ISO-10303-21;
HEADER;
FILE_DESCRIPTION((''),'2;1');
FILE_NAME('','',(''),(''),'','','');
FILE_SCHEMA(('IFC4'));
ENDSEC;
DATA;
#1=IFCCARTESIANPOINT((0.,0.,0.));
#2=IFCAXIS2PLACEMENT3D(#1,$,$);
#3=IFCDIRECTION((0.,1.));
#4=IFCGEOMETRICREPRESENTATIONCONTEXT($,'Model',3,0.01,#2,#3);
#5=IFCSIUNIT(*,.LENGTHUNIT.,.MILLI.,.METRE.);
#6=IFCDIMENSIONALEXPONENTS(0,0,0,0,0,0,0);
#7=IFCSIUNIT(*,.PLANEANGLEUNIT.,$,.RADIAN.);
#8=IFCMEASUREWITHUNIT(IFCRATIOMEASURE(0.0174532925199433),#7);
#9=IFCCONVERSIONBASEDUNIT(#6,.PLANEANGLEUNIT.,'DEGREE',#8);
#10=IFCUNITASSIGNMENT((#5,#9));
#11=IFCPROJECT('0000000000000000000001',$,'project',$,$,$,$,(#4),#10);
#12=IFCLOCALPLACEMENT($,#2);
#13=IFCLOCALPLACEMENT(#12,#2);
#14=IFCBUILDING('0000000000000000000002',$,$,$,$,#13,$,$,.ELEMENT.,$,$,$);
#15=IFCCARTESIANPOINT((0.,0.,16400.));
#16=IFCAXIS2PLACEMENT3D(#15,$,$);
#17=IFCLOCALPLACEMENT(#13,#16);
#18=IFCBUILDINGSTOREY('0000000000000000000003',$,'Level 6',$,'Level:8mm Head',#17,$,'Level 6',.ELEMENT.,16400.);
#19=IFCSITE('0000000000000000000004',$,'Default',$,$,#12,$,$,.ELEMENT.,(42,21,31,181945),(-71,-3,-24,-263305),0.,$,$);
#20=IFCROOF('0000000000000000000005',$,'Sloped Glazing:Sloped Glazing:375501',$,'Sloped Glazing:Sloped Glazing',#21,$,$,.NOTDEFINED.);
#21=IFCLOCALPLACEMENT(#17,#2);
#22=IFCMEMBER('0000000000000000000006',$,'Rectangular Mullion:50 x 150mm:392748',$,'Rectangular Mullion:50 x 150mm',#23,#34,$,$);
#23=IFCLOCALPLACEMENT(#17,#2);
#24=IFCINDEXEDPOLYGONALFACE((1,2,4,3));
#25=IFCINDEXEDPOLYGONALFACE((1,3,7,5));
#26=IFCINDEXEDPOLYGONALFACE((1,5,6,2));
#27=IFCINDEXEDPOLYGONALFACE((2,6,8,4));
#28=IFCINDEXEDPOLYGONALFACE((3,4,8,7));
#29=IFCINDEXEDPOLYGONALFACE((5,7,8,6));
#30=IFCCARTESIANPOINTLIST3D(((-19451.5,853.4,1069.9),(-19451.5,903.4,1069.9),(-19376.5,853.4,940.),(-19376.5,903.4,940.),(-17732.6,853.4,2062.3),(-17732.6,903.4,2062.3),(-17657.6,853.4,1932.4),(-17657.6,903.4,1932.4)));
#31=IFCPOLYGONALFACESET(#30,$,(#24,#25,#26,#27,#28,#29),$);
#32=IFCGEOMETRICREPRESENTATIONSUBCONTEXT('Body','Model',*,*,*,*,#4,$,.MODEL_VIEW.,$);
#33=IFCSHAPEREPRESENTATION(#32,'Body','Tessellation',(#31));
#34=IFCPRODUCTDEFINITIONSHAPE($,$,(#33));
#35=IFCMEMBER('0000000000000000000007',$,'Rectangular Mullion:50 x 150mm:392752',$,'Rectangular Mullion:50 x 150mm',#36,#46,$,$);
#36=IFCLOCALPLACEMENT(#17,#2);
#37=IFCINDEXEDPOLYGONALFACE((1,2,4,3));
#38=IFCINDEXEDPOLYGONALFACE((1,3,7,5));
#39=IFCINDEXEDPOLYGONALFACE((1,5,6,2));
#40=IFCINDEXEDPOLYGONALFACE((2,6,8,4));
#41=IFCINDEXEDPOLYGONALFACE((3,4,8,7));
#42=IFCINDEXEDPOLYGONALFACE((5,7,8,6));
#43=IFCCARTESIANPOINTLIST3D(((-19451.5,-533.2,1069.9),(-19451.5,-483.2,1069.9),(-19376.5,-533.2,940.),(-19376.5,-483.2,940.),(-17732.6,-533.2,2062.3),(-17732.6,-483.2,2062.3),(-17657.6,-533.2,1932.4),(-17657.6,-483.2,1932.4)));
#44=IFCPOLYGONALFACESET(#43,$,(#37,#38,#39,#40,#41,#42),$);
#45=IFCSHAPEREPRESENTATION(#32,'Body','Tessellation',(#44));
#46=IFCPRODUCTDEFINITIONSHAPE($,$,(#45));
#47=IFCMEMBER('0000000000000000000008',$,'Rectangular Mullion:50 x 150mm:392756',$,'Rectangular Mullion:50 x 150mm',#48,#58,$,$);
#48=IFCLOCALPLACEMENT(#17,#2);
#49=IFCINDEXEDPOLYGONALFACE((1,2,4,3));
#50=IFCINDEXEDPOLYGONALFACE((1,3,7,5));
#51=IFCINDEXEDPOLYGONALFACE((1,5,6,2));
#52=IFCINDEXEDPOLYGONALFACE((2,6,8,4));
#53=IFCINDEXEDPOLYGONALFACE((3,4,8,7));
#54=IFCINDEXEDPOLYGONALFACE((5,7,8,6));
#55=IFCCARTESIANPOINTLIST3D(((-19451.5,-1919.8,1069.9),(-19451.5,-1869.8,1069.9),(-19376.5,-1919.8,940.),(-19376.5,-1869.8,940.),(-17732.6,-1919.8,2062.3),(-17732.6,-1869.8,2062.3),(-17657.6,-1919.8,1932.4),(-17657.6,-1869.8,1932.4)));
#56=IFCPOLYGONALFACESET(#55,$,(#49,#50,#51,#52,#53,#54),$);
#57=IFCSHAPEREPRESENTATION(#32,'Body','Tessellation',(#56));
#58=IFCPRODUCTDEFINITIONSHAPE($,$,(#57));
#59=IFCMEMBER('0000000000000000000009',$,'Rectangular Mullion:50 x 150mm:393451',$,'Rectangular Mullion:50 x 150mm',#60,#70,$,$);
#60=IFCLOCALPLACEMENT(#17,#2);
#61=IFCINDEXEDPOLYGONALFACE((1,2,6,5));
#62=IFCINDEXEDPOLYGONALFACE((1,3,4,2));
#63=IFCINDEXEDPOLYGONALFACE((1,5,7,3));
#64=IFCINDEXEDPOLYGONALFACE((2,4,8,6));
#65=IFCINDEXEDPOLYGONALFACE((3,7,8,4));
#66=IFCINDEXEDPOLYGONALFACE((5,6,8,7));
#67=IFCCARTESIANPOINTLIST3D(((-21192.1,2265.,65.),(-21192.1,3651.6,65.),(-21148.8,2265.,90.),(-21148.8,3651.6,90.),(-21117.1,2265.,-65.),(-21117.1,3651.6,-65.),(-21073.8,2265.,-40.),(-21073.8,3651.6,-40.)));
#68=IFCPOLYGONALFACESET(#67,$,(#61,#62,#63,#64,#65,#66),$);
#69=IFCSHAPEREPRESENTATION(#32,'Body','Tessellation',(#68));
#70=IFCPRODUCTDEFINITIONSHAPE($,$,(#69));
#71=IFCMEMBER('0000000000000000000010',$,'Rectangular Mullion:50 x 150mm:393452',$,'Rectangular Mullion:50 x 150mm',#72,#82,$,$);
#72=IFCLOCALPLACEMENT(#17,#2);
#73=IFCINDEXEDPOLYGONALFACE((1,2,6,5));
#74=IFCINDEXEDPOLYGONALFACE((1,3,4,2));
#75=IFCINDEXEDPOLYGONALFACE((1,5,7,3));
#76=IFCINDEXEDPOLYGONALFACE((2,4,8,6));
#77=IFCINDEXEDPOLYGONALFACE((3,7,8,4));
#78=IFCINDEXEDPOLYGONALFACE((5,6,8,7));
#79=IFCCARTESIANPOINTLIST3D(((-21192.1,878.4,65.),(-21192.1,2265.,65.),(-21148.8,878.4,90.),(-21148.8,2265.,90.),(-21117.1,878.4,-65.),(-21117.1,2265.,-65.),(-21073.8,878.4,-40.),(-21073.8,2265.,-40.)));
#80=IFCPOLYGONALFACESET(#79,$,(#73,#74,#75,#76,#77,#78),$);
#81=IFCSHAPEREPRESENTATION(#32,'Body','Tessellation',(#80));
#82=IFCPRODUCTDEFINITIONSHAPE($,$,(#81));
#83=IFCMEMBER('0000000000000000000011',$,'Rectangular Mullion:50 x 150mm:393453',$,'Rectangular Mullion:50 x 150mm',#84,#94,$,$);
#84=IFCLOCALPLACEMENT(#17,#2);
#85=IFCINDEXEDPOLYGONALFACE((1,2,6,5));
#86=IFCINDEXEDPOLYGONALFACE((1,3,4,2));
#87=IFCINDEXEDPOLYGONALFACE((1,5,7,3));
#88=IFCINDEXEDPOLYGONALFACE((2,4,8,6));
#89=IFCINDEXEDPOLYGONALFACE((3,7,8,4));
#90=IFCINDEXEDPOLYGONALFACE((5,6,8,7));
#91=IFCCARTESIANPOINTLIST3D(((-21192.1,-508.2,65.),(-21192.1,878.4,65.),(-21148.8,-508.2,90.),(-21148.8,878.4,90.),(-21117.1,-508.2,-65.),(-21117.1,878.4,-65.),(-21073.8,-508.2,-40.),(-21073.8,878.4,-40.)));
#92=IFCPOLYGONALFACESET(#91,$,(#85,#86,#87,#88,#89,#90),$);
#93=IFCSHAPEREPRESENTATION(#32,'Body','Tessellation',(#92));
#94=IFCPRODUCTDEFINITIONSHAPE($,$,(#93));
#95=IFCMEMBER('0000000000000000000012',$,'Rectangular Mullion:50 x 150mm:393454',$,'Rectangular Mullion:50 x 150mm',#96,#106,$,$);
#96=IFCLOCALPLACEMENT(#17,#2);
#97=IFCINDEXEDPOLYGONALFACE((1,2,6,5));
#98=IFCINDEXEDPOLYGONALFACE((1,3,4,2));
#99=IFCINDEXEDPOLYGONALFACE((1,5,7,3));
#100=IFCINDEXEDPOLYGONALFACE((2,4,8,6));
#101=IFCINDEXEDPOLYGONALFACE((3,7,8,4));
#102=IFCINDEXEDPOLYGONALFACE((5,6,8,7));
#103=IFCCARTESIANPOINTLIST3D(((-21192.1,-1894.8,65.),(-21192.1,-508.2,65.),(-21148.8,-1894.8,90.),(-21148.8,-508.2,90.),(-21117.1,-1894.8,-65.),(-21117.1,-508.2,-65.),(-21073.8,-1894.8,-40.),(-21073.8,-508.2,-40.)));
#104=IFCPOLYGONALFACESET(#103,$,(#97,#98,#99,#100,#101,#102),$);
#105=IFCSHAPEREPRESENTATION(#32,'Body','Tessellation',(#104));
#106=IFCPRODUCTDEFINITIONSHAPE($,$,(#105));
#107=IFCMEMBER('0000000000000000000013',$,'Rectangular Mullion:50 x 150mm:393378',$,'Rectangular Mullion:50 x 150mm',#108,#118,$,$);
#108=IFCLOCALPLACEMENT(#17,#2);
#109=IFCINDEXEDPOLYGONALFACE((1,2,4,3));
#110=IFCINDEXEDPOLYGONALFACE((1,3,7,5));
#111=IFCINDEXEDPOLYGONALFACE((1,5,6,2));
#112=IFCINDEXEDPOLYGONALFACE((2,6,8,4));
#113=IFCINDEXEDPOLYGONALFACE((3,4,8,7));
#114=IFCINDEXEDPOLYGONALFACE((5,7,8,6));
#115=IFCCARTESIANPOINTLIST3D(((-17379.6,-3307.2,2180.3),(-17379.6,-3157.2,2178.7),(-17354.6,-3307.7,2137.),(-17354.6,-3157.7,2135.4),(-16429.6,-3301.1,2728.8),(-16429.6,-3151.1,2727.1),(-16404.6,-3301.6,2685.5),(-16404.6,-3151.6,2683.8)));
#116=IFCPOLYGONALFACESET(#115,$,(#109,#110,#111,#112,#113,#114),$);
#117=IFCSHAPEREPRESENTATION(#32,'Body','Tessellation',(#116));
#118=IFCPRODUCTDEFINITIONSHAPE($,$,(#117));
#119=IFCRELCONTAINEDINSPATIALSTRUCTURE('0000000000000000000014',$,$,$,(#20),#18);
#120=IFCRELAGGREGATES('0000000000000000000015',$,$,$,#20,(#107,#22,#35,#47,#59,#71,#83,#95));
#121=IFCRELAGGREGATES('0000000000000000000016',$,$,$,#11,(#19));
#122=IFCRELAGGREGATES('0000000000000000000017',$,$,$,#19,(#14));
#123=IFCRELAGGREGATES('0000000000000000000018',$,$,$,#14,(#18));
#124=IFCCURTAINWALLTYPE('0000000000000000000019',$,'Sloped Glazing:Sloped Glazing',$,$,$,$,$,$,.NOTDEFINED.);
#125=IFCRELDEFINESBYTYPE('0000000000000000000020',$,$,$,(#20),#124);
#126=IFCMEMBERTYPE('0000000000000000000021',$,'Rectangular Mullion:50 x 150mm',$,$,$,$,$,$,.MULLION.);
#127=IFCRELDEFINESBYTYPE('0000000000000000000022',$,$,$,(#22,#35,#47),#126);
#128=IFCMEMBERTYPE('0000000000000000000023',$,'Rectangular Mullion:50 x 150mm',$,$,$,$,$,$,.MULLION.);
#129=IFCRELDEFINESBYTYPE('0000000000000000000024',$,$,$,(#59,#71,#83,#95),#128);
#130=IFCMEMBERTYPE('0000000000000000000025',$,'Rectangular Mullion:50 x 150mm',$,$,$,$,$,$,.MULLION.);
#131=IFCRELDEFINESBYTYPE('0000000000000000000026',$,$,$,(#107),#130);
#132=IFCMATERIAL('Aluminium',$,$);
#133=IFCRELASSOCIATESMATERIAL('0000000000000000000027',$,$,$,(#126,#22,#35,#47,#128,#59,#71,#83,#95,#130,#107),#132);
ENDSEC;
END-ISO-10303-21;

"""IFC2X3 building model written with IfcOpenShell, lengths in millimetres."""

from ifc_helpers import new_model, entity, si_unit, converted_unit, direction, frame, origin, origin_2d_with_axis, place, context, subcontext, project, spatial, rectangle, extrude, source, transform, mapped, material, type_object, type_shapes, element, aggregate, save


model = new_model("IFC2X3")

# Units and contexts
model_context = context("Model", 3, precision=0.01, world=origin(), true_north=direction((0.0, 1.0)))
body_context = subcontext(model_context, "Body", "Model", "MODEL_VIEW")
ifc_project = project(units=[si_unit("LENGTHUNIT", "METRE", prefix="MILLI"), converted_unit("PLANEANGLEUNIT", "DEGREE", entity("IfcRatioMeasure", 0.0174532925199433), si_unit("PLANEANGLEUNIT", "RADIAN"), dimensions=[0, 0, 0, 0, 0, 0, 0])], contexts=[model_context])

# Site, building, storey
site_placement = place(None, frame((0.0, 0.0, 0.0)))
site = spatial("IfcSite", under=ifc_project, at=site_placement, Name="Default", CompositionType="ELEMENT", RefLatitude=(42, 21, 31, 181945), RefLongitude=(-71, -3, -24, -263305), RefElevation=0.0)
building_placement = place(site_placement, origin())
building = spatial("IfcBuilding", under=site, at=building_placement, CompositionType="ELEMENT")
storey_placement = place(building_placement, frame((0.0, 0.0, 16400.0)))
storey = spatial("IfcBuildingStorey", under=building, at=storey_placement, Name="Level 6", ObjectType="Level:8mm Head", LongName="Level 6", CompositionType="ELEMENT", Elevation=16400.0)

# Roof, members
curtain_wall_type = type_object("IfcCurtainWallType", Name="Sloped Glazing:Sloped Glazing", PredefinedType="NOTDEFINED")
roof_placement = place(storey_placement, frame((0.0, 0.0, -16400.0)))
roof = element("IfcRoof", 1, at=roof_placement, inside=storey, type_object=curtain_wall_type, Name="Sloped Glazing:Sloped Glazing:375501", ObjectType="Sloped Glazing:Sloped Glazing", ShapeType="NOTDEFINED")
ifc_material_1 = material(Name="Aluminium")
member_type_1 = type_object("IfcMemberType", Name="Rectangular Mullion:50 x 150mm", PredefinedType="MULLION", material=ifc_material_1)
shared_shape_1 = source(origin(), body_context, "Body", "SweptSolid", [
    extrude(rectangle(XDim=150.0, YDim=50.0, at=origin_2d_with_axis()), frame((0.0, 0.0, -1984.8), z_axis=(0.0, 0.0, 1.0), x_axis=(0.0, -1.0, 0.0)), (0.0, 0.0, 1.0), 1984.8),
])
type_shapes(member_type_1, [shared_shape_1])
member_1_placement = place(storey_placement, frame((-17695.1, 878.4, 1997.3), z_axis=(0.866025, 0.0, 0.5), x_axis=(0.0, -1.0, 0.0)))
member_1 = element("IfcMember", 2, at=member_1_placement, type_object=member_type_1, material=ifc_material_1, Name="Rectangular Mullion:50 x 150mm:392748", ObjectType="Rectangular Mullion:50 x 150mm", context=body_context, shape_type="MappedRepresentation", body=[
    mapped(shared_shape_1, transform((0.0, 0.0, 0.0), scale=1.0)),
])
member_2_placement = place(storey_placement, frame((-17695.1, -508.2, 1997.3), z_axis=(0.866025, 0.0, 0.5), x_axis=(0.0, -1.0, 0.0)))
member_2 = element("IfcMember", 3, at=member_2_placement, type_object=member_type_1, material=ifc_material_1, Name="Rectangular Mullion:50 x 150mm:392752", ObjectType="Rectangular Mullion:50 x 150mm", context=body_context, shape_type="MappedRepresentation", body=[
    mapped(shared_shape_1, transform((0.0, 0.0, 0.0), scale=1.0)),
])
member_3_placement = place(storey_placement, frame((-17695.1, -1894.8, 1997.3), z_axis=(0.866025, 0.0, 0.5), x_axis=(0.0, -1.0, 0.0)))
member_3 = element("IfcMember", 4, at=member_3_placement, type_object=member_type_1, material=ifc_material_1, Name="Rectangular Mullion:50 x 150mm:392756", ObjectType="Rectangular Mullion:50 x 150mm", context=body_context, shape_type="MappedRepresentation", body=[
    mapped(shared_shape_1, transform((0.0, 0.0, 0.0), scale=1.0)),
])
member_type_2 = type_object("IfcMemberType", Name="Rectangular Mullion:50 x 150mm", PredefinedType="MULLION", material=ifc_material_1)
shared_shape_2 = source(origin(), body_context, "Body", "SweptSolid", [
    extrude(rectangle(XDim=150.0, YDim=50.0, at=origin_2d_with_axis()), frame((-25.0, 0.0, -1386.6), z_axis=(0.0, 0.0, 1.0), x_axis=(0.0, -1.0, 0.0)), (0.0, 0.0, 1.0), 1386.6),
])
type_shapes(member_type_2, [shared_shape_2])
member_4_placement = place(storey_placement, frame((-21154.6, 2265.0, 0.0), z_axis=(0.0, -1.0, 0.0), x_axis=(-0.866025, 0.0, -0.5)))
member_4 = element("IfcMember", 5, at=member_4_placement, type_object=member_type_2, material=ifc_material_1, Name="Rectangular Mullion:50 x 150mm:393451", ObjectType="Rectangular Mullion:50 x 150mm", context=body_context, shape_type="MappedRepresentation", body=[
    mapped(shared_shape_2, transform((0.0, 0.0, 0.0), scale=1.0)),
])
member_5_placement = place(storey_placement, frame((-21154.6, 878.4, 0.0), z_axis=(0.0, -1.0, 0.0), x_axis=(-0.866025, 0.0, -0.5)))
member_5 = element("IfcMember", 6, at=member_5_placement, type_object=member_type_2, material=ifc_material_1, Name="Rectangular Mullion:50 x 150mm:393452", ObjectType="Rectangular Mullion:50 x 150mm", context=body_context, shape_type="MappedRepresentation", body=[
    mapped(shared_shape_2, transform((0.0, 0.0, 0.0), scale=1.0)),
])
member_6_placement = place(storey_placement, frame((-21154.6, -508.2, 0.0), z_axis=(0.0, -1.0, 0.0), x_axis=(-0.866025, 0.0, -0.5)))
member_6 = element("IfcMember", 7, at=member_6_placement, type_object=member_type_2, material=ifc_material_1, Name="Rectangular Mullion:50 x 150mm:393453", ObjectType="Rectangular Mullion:50 x 150mm", context=body_context, shape_type="MappedRepresentation", body=[
    mapped(shared_shape_2, transform((0.0, 0.0, 0.0), scale=1.0)),
])
member_7_placement = place(storey_placement, frame((-21154.6, -1894.8, 0.0), z_axis=(0.0, -1.0, 0.0), x_axis=(-0.866025, 0.0, -0.5)))
member_7 = element("IfcMember", 8, at=member_7_placement, type_object=member_type_2, material=ifc_material_1, Name="Rectangular Mullion:50 x 150mm:393454", ObjectType="Rectangular Mullion:50 x 150mm", context=body_context, shape_type="MappedRepresentation", body=[
    mapped(shared_shape_2, transform((0.0, 0.0, 0.0), scale=1.0)),
])
member_type_3 = type_object("IfcMemberType", Name="Rectangular Mullion:50 x 150mm", PredefinedType="MULLION", material=ifc_material_1)
shared_shape_3 = source(origin(), body_context, "Body", "SweptSolid", [
    extrude(rectangle(XDim=150.0, YDim=50.0, at=origin_2d_with_axis()), frame((-25.0, 0.0, -1097.0), z_axis=(0.0, 0.0, 1.0), x_axis=(0.0, -1.0, 0.0)), (0.0, 0.0, 1.0), 1097.0),
])
type_shapes(member_type_3, [shared_shape_3])
member_8_placement = place(storey_placement, frame((-17379.6, -3232.2, 2179.5), z_axis=(-0.866012, -0.005555, -0.499992), x_axis=(-0.500023, 0.009622, 0.865959)))
member_8 = element("IfcMember", 9, at=member_8_placement, type_object=member_type_3, material=ifc_material_1, Name="Rectangular Mullion:50 x 150mm:393378", ObjectType="Rectangular Mullion:50 x 150mm", context=body_context, shape_type="MappedRepresentation", body=[
    mapped(shared_shape_3, transform((0.0, 0.0, 0.0), scale=1.0)),
])
aggregate(roof, [member_8, member_1, member_2, member_3, member_4, member_5, member_6, member_7])

save(model, "model.ifc")
